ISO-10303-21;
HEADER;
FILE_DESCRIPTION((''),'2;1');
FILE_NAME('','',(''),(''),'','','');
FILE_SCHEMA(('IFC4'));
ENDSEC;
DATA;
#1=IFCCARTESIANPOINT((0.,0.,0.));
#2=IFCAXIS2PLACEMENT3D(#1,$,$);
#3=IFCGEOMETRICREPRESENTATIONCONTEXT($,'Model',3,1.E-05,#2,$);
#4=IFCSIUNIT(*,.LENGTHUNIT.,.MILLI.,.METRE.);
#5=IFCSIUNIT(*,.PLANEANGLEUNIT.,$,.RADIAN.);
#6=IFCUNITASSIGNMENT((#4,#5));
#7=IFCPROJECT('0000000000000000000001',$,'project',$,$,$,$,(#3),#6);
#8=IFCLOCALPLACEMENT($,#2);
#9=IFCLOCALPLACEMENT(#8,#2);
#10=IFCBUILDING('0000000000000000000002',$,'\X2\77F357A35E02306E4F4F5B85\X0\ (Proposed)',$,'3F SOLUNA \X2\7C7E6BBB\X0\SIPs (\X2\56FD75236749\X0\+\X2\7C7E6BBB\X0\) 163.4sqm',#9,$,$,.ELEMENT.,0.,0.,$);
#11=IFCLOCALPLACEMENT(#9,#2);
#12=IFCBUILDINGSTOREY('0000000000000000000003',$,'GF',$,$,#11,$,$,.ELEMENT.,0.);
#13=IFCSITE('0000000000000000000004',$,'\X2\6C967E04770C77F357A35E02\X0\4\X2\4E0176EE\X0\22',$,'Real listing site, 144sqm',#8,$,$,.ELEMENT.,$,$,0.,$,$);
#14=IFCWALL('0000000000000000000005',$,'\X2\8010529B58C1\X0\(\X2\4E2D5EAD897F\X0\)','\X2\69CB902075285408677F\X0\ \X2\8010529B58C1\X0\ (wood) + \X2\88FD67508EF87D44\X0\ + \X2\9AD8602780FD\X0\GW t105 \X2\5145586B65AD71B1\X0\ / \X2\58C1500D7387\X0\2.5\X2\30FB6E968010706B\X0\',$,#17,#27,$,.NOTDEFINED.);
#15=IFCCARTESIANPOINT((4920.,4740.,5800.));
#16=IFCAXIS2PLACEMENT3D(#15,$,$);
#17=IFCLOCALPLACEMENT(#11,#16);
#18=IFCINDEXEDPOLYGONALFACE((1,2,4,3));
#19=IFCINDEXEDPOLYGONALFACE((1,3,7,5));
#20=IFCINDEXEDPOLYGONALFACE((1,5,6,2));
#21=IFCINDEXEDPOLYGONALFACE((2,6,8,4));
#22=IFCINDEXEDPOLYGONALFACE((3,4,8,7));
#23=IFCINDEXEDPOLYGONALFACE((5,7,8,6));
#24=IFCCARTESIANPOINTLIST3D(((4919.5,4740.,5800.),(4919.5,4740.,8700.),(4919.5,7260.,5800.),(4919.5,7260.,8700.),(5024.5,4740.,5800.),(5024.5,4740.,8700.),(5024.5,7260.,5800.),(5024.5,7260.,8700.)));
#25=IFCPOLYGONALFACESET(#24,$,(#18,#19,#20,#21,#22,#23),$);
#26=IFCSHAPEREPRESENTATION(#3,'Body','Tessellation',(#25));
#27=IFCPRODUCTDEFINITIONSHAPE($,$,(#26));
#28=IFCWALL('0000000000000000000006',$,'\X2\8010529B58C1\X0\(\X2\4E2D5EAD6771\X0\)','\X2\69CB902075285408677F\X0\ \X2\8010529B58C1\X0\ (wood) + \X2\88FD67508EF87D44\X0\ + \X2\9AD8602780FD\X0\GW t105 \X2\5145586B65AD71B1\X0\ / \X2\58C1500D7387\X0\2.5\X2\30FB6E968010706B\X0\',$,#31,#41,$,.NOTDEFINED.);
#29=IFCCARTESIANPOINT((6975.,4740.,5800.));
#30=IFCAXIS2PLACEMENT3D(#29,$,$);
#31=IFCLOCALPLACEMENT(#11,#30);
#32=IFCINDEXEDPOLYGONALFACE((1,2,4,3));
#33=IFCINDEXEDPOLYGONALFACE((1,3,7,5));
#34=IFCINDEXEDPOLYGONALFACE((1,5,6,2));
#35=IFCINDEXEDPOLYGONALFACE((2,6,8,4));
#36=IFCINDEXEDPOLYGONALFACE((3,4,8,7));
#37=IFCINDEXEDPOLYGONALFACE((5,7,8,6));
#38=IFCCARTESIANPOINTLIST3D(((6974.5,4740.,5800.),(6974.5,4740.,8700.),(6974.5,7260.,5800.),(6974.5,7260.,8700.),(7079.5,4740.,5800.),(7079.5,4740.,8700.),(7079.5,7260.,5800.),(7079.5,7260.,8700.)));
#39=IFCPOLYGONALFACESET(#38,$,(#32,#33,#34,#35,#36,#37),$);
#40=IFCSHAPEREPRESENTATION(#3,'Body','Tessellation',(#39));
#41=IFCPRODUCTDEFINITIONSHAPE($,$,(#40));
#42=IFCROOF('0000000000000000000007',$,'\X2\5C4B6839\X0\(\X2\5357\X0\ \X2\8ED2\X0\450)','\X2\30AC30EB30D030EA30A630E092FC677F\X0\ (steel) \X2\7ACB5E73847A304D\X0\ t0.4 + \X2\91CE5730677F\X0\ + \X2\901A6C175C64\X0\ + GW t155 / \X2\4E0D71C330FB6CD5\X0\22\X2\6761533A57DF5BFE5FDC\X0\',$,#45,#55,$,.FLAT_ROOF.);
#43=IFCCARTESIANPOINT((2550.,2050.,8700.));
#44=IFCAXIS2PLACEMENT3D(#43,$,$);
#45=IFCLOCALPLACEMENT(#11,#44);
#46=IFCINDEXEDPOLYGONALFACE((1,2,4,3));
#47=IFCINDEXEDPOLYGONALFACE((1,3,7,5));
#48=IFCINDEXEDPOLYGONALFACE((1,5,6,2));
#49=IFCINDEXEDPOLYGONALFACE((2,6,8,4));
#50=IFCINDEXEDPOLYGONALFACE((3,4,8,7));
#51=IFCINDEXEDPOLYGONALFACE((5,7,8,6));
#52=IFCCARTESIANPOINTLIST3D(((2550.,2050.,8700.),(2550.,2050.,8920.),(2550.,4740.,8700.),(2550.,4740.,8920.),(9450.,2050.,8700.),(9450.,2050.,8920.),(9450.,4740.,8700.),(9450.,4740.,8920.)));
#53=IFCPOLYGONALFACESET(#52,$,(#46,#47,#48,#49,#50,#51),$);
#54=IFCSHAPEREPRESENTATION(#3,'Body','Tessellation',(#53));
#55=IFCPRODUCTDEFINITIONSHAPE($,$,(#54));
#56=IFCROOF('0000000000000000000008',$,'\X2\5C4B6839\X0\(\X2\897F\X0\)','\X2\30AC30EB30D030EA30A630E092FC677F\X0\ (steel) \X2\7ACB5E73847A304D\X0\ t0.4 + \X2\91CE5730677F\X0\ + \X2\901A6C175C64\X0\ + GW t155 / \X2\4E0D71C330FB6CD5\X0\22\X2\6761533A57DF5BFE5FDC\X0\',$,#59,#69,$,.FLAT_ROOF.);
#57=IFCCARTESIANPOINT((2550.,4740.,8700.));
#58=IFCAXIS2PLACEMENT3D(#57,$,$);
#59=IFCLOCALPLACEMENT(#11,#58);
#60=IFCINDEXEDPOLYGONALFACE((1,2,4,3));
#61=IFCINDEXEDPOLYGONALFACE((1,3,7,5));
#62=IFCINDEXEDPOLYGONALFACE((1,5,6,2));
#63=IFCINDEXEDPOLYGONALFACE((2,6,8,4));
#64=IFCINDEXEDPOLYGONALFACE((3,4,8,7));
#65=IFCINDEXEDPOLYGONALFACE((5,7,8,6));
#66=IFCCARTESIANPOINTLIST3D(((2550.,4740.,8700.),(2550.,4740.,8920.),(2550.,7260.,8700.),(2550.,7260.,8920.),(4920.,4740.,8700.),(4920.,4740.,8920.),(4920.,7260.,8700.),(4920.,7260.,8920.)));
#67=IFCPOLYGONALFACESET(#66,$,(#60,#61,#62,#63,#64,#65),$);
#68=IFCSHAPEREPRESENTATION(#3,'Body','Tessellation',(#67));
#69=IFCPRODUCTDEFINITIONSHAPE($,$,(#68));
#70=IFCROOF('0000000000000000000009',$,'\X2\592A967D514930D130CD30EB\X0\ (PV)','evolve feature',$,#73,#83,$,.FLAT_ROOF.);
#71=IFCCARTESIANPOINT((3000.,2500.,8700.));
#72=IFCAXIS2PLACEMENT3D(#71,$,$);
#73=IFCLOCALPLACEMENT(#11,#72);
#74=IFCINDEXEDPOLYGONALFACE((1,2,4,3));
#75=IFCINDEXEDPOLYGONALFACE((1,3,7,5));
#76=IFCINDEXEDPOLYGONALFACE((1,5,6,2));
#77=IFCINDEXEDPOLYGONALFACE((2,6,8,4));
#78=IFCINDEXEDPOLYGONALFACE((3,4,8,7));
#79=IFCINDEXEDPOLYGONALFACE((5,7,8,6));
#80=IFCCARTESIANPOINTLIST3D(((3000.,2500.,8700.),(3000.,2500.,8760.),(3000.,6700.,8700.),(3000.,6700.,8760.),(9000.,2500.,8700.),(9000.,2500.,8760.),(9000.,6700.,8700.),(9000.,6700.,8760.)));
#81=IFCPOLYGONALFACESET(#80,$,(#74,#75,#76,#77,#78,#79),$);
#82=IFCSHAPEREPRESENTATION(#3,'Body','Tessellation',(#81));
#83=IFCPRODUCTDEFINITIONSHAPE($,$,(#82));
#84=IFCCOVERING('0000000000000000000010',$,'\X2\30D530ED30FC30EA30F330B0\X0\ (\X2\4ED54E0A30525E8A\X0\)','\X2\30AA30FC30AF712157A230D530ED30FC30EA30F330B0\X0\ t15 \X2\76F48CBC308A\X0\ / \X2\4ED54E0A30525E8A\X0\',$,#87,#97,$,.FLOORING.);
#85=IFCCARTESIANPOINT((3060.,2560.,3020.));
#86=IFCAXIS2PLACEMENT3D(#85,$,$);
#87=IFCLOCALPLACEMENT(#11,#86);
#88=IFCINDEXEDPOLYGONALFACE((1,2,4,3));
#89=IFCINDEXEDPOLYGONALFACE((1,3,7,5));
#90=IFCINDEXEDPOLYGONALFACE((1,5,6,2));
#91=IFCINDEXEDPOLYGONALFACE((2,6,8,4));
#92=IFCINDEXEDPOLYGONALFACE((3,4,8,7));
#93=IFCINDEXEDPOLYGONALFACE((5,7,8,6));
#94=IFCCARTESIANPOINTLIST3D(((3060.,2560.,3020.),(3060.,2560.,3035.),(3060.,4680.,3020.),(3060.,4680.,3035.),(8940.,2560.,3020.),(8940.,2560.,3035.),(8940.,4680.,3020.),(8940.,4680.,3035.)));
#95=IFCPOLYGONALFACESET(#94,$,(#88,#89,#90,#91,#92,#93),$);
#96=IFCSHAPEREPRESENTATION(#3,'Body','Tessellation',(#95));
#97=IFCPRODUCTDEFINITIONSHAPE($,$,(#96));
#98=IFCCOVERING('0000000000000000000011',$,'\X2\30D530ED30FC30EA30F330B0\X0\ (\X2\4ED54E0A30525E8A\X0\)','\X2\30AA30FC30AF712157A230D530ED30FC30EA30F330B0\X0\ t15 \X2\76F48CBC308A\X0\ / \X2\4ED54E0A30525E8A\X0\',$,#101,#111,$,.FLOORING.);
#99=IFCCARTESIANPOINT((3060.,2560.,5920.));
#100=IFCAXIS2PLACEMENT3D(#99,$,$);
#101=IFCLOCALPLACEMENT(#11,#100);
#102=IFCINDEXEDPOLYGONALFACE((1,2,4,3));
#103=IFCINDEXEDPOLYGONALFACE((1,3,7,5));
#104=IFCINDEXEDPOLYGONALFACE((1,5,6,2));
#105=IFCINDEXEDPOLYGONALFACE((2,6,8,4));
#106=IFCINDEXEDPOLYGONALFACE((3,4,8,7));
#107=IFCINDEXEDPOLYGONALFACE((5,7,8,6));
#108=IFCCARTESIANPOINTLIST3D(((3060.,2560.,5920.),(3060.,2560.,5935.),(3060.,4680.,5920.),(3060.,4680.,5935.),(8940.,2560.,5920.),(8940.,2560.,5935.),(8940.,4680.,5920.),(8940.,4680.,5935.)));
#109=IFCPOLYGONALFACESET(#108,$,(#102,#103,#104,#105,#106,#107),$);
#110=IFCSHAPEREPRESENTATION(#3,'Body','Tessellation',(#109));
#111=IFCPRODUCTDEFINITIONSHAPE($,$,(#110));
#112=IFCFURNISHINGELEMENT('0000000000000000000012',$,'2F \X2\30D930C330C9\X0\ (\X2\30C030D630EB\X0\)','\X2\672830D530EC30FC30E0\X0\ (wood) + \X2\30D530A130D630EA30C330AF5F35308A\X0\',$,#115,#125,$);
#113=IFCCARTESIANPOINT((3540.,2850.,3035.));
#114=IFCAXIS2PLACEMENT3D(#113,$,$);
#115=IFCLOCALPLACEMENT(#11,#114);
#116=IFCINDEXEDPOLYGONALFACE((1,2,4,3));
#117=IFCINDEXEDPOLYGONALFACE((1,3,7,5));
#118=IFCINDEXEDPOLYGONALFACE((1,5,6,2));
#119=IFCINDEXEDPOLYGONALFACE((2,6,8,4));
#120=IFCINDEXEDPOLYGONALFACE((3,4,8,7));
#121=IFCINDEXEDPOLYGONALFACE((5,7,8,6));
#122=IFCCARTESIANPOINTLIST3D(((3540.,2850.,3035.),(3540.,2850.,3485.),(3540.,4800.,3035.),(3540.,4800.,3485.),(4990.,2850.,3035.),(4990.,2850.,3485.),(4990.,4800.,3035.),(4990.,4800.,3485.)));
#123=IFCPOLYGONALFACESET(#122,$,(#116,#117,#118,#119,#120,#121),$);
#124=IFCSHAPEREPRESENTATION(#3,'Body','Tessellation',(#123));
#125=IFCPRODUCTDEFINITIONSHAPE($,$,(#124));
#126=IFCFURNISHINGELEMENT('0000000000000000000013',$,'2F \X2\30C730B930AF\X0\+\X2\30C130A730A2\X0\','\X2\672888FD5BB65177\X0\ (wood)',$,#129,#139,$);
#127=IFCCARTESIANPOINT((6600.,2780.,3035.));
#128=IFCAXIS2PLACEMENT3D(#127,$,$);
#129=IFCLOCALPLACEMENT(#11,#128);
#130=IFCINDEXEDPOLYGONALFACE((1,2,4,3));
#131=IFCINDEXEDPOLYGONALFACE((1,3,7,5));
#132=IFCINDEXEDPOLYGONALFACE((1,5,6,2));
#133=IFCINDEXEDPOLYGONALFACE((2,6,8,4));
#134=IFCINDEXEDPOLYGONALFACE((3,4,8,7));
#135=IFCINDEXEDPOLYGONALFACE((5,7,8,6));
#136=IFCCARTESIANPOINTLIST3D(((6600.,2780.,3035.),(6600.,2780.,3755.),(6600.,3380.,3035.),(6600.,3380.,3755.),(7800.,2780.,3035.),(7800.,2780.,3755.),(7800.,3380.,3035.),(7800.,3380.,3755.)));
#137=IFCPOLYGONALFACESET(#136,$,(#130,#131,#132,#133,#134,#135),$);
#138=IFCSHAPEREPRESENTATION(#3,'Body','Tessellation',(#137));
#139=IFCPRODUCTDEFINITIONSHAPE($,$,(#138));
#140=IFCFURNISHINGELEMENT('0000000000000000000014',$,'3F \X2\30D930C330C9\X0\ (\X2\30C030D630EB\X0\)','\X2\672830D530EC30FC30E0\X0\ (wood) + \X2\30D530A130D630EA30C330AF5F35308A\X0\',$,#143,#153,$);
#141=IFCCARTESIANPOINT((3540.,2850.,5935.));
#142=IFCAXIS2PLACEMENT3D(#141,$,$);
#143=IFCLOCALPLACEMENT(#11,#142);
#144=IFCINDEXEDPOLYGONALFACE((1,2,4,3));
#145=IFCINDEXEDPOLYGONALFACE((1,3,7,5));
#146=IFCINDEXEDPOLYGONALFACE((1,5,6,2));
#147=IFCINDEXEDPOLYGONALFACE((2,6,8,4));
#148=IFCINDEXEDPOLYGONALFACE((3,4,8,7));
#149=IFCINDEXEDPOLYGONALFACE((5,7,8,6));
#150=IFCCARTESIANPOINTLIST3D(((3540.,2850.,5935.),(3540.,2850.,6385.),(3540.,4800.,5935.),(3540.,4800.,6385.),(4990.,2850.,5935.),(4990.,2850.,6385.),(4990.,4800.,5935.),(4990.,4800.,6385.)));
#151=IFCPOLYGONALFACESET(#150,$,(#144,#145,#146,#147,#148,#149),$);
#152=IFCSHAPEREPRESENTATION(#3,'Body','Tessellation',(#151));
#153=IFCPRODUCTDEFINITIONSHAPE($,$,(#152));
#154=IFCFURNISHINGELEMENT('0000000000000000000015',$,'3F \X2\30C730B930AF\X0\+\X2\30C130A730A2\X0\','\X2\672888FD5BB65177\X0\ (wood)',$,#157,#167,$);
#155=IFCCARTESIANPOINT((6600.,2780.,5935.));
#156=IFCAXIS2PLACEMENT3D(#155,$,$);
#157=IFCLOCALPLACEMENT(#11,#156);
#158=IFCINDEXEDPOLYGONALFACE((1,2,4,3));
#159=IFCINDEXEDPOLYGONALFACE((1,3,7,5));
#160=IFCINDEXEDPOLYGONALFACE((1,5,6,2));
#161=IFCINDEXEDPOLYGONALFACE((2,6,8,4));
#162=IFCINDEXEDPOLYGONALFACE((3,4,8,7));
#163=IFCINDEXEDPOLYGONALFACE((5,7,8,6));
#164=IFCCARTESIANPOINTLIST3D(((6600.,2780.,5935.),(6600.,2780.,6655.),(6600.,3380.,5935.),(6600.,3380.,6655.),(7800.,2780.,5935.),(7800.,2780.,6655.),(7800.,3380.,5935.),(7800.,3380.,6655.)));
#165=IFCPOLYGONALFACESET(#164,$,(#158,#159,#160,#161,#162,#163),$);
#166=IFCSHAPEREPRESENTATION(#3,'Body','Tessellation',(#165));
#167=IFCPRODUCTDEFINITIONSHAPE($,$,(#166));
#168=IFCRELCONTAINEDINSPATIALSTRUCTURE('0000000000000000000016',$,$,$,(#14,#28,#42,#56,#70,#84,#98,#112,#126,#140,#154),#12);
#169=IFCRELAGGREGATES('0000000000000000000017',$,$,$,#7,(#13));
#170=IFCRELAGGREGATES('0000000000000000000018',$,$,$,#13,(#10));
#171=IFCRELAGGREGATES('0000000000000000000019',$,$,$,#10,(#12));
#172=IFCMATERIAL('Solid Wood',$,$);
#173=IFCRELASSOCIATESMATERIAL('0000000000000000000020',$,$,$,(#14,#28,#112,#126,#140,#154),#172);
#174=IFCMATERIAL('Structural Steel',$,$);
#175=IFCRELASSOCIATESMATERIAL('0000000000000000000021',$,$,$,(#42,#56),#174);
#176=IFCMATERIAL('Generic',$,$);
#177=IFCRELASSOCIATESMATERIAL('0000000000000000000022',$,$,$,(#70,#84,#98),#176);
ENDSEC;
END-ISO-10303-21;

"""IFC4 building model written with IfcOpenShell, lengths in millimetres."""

from ifc_helpers import new_model, si_unit, frame, frame_2d, origin, place, context, project, spatial, rectangle, extrude, material, element, save


model = new_model("IFC4")

# Units and contexts
model_context = context("Model", 3, precision=1e-05, world=origin())
ifc_project = project(units=[si_unit("LENGTHUNIT", "METRE", prefix="MILLI"), si_unit("PLANEANGLEUNIT", "RADIAN")], contexts=[model_context])

# Site, building, storey
site_placement = place(None, origin())
site = spatial("IfcSite", under=ifc_project, at=site_placement, Name="沖縄県石垣市4丁目22", ObjectType="Real listing site, 144sqm", CompositionType="ELEMENT", RefElevation=0.0)
building_placement = place(site_placement, origin())
building = spatial("IfcBuilding", under=site, at=building_placement, Name="石垣市の住宅 (Proposed)", ObjectType="3F SOLUNA 籾殻SIPs (国産杉+籾殻) 163.4sqm", CompositionType="ELEMENT", ElevationOfRefHeight=0.0, ElevationOfTerrain=0.0)
storey_placement = place(building_placement, origin())
storey = spatial("IfcBuildingStorey", under=building, at=storey_placement, Name="GF", CompositionType="ELEMENT", Elevation=0.0)

# Shared definitions
ifc_material_1 = material(Name="Solid Wood")

# Walls
wall_1_placement = place(storey_placement, frame((4920.0, 4740.0, 5800.0)))
element("IfcWall", 1, at=wall_1_placement, inside=storey, material=ifc_material_1, Name="耐力壁(中庭西)", Description="構造用合板 耐力壁 (wood) + 製材軸組 + 高性能GW t105 充填断熱 / 壁倍率2.5・準耐火", PredefinedType="NOTDEFINED", context=model_context, shape_type="SweptSolid", body=[
    extrude(rectangle(XDim=105.0, YDim=2520.0, at=frame_2d((52.0, 1260.0))), frame((4920.0, 4740.0, 5800.0)), (0.0, 0.0, 1.0), 2900.0),
])
wall_2_placement = place(storey_placement, frame((6975.0, 4740.0, 5800.0)))
element("IfcWall", 2, at=wall_2_placement, inside=storey, material=ifc_material_1, Name="耐力壁(中庭東)", Description="構造用合板 耐力壁 (wood) + 製材軸組 + 高性能GW t105 充填断熱 / 壁倍率2.5・準耐火", PredefinedType="NOTDEFINED", context=model_context, shape_type="SweptSolid", body=[
    extrude(rectangle(XDim=105.0, YDim=2520.0, at=frame_2d((52.0, 1260.0))), frame((6975.0, 4740.0, 5800.0)), (0.0, 0.0, 1.0), 2900.0),
])

# Roofs
ifc_material_2 = material(Name="Structural Steel")
roof_1_placement = place(storey_placement, frame((2550.0, 2050.0, 8700.0)))
element("IfcRoof", 3, at=roof_1_placement, inside=storey, material=ifc_material_2, Name="屋根(南 軒450)", Description="ガルバリウム鋼板 (steel) 立平葺き t0.4 + 野地板 + 通気層 + GW t155 / 不燃・法22条区域対応", PredefinedType="FLAT_ROOF", context=model_context, shape_type="SweptSolid", body=[
    extrude(rectangle(XDim=6900.0, YDim=2690.0, at=frame_2d((3450.0, 1345.0))), frame((2550.0, 2050.0, 8700.0)), (0.0, 0.0, 1.0), 220.0),
])
roof_2_placement = place(storey_placement, frame((2550.0, 4740.0, 8700.0)))
element("IfcRoof", 4, at=roof_2_placement, inside=storey, material=ifc_material_2, Name="屋根(西)", Description="ガルバリウム鋼板 (steel) 立平葺き t0.4 + 野地板 + 通気層 + GW t155 / 不燃・法22条区域対応", PredefinedType="FLAT_ROOF", context=model_context, shape_type="SweptSolid", body=[
    extrude(rectangle(XDim=2370.0, YDim=2520.0, at=frame_2d((1185.0, 1260.0))), frame((2550.0, 4740.0, 8700.0)), (0.0, 0.0, 1.0), 220.0),
])
ifc_material_3 = material(Name="Generic")
roof_3_placement = place(storey_placement, frame((3000.0, 2500.0, 8700.0)))
element("IfcRoof", 5, at=roof_3_placement, inside=storey, material=ifc_material_3, Name="太陽光パネル (PV)", Description="evolve feature", PredefinedType="FLAT_ROOF", context=model_context, shape_type="SweptSolid", body=[
    extrude(rectangle(XDim=6000.0, YDim=4200.0, at=frame_2d((3000.0, 2100.0))), frame((3000.0, 2500.0, 8700.0)), (0.0, 0.0, 1.0), 60.0),
])

# Coverings
covering_1_placement = place(storey_placement, frame((3060.0, 2560.0, 3020.0)))
element("IfcCovering", 6, at=covering_1_placement, inside=storey, material=ifc_material_3, Name="フローリング (仕上げ床)", Description="オーク無垢フローリング t15 直貼り / 仕上げ床", PredefinedType="FLOORING", context=model_context, shape_type="SweptSolid", body=[
    extrude(rectangle(XDim=5880.0, YDim=2120.0, at=frame_2d((2940.0, 1060.0))), frame((3060.0, 2560.0, 3020.0)), (0.0, 0.0, 1.0), 15.0),
])
covering_2_placement = place(storey_placement, frame((3060.0, 2560.0, 5920.0)))
element("IfcCovering", 7, at=covering_2_placement, inside=storey, material=ifc_material_3, Name="フローリング (仕上げ床)", Description="オーク無垢フローリング t15 直貼り / 仕上げ床", PredefinedType="FLOORING", context=model_context, shape_type="SweptSolid", body=[
    extrude(rectangle(XDim=5880.0, YDim=2120.0, at=frame_2d((2940.0, 1060.0))), frame((3060.0, 2560.0, 5920.0)), (0.0, 0.0, 1.0), 15.0),
])

# Furnishing elements
furnishing_1_placement = place(storey_placement, frame((3540.0, 2850.0, 3035.0)))
element("IfcFurnishingElement", 8, at=furnishing_1_placement, inside=storey, material=ifc_material_1, Name="2F ベッド (ダブル)", Description="木フレーム (wood) + ファブリック張り", context=model_context, shape_type="SweptSolid", body=[
    extrude(rectangle(XDim=1450.0, YDim=1950.0, at=frame_2d((725.0, 975.0))), frame((3540.0, 2850.0, 3035.0)), (0.0, 0.0, 1.0), 450.0),
])
furnishing_2_placement = place(storey_placement, frame((6600.0, 2780.0, 3035.0)))
element("IfcFurnishingElement", 9, at=furnishing_2_placement, inside=storey, material=ifc_material_1, Name="2F デスク+チェア", Description="木製家具 (wood)", context=model_context, shape_type="SweptSolid", body=[
    extrude(rectangle(XDim=1200.0, YDim=600.0, at=frame_2d((600.0, 300.0))), frame((6600.0, 2780.0, 3035.0)), (0.0, 0.0, 1.0), 720.0),
])
furnishing_3_placement = place(storey_placement, frame((3540.0, 2850.0, 5935.0)))
element("IfcFurnishingElement", 10, at=furnishing_3_placement, inside=storey, material=ifc_material_1, Name="3F ベッド (ダブル)", Description="木フレーム (wood) + ファブリック張り", context=model_context, shape_type="SweptSolid", body=[
    extrude(rectangle(XDim=1450.0, YDim=1950.0, at=frame_2d((725.0, 975.0))), frame((3540.0, 2850.0, 5935.0)), (0.0, 0.0, 1.0), 450.0),
])
furnishing_4_placement = place(storey_placement, frame((6600.0, 2780.0, 5935.0)))
element("IfcFurnishingElement", 11, at=furnishing_4_placement, inside=storey, material=ifc_material_1, Name="3F デスク+チェア", Description="木製家具 (wood)", context=model_context, shape_type="SweptSolid", body=[
    extrude(rectangle(XDim=1200.0, YDim=600.0, at=frame_2d((600.0, 300.0))), frame((6600.0, 2780.0, 5935.0)), (0.0, 0.0, 1.0), 720.0),
])

save(model, "model.ifc")
